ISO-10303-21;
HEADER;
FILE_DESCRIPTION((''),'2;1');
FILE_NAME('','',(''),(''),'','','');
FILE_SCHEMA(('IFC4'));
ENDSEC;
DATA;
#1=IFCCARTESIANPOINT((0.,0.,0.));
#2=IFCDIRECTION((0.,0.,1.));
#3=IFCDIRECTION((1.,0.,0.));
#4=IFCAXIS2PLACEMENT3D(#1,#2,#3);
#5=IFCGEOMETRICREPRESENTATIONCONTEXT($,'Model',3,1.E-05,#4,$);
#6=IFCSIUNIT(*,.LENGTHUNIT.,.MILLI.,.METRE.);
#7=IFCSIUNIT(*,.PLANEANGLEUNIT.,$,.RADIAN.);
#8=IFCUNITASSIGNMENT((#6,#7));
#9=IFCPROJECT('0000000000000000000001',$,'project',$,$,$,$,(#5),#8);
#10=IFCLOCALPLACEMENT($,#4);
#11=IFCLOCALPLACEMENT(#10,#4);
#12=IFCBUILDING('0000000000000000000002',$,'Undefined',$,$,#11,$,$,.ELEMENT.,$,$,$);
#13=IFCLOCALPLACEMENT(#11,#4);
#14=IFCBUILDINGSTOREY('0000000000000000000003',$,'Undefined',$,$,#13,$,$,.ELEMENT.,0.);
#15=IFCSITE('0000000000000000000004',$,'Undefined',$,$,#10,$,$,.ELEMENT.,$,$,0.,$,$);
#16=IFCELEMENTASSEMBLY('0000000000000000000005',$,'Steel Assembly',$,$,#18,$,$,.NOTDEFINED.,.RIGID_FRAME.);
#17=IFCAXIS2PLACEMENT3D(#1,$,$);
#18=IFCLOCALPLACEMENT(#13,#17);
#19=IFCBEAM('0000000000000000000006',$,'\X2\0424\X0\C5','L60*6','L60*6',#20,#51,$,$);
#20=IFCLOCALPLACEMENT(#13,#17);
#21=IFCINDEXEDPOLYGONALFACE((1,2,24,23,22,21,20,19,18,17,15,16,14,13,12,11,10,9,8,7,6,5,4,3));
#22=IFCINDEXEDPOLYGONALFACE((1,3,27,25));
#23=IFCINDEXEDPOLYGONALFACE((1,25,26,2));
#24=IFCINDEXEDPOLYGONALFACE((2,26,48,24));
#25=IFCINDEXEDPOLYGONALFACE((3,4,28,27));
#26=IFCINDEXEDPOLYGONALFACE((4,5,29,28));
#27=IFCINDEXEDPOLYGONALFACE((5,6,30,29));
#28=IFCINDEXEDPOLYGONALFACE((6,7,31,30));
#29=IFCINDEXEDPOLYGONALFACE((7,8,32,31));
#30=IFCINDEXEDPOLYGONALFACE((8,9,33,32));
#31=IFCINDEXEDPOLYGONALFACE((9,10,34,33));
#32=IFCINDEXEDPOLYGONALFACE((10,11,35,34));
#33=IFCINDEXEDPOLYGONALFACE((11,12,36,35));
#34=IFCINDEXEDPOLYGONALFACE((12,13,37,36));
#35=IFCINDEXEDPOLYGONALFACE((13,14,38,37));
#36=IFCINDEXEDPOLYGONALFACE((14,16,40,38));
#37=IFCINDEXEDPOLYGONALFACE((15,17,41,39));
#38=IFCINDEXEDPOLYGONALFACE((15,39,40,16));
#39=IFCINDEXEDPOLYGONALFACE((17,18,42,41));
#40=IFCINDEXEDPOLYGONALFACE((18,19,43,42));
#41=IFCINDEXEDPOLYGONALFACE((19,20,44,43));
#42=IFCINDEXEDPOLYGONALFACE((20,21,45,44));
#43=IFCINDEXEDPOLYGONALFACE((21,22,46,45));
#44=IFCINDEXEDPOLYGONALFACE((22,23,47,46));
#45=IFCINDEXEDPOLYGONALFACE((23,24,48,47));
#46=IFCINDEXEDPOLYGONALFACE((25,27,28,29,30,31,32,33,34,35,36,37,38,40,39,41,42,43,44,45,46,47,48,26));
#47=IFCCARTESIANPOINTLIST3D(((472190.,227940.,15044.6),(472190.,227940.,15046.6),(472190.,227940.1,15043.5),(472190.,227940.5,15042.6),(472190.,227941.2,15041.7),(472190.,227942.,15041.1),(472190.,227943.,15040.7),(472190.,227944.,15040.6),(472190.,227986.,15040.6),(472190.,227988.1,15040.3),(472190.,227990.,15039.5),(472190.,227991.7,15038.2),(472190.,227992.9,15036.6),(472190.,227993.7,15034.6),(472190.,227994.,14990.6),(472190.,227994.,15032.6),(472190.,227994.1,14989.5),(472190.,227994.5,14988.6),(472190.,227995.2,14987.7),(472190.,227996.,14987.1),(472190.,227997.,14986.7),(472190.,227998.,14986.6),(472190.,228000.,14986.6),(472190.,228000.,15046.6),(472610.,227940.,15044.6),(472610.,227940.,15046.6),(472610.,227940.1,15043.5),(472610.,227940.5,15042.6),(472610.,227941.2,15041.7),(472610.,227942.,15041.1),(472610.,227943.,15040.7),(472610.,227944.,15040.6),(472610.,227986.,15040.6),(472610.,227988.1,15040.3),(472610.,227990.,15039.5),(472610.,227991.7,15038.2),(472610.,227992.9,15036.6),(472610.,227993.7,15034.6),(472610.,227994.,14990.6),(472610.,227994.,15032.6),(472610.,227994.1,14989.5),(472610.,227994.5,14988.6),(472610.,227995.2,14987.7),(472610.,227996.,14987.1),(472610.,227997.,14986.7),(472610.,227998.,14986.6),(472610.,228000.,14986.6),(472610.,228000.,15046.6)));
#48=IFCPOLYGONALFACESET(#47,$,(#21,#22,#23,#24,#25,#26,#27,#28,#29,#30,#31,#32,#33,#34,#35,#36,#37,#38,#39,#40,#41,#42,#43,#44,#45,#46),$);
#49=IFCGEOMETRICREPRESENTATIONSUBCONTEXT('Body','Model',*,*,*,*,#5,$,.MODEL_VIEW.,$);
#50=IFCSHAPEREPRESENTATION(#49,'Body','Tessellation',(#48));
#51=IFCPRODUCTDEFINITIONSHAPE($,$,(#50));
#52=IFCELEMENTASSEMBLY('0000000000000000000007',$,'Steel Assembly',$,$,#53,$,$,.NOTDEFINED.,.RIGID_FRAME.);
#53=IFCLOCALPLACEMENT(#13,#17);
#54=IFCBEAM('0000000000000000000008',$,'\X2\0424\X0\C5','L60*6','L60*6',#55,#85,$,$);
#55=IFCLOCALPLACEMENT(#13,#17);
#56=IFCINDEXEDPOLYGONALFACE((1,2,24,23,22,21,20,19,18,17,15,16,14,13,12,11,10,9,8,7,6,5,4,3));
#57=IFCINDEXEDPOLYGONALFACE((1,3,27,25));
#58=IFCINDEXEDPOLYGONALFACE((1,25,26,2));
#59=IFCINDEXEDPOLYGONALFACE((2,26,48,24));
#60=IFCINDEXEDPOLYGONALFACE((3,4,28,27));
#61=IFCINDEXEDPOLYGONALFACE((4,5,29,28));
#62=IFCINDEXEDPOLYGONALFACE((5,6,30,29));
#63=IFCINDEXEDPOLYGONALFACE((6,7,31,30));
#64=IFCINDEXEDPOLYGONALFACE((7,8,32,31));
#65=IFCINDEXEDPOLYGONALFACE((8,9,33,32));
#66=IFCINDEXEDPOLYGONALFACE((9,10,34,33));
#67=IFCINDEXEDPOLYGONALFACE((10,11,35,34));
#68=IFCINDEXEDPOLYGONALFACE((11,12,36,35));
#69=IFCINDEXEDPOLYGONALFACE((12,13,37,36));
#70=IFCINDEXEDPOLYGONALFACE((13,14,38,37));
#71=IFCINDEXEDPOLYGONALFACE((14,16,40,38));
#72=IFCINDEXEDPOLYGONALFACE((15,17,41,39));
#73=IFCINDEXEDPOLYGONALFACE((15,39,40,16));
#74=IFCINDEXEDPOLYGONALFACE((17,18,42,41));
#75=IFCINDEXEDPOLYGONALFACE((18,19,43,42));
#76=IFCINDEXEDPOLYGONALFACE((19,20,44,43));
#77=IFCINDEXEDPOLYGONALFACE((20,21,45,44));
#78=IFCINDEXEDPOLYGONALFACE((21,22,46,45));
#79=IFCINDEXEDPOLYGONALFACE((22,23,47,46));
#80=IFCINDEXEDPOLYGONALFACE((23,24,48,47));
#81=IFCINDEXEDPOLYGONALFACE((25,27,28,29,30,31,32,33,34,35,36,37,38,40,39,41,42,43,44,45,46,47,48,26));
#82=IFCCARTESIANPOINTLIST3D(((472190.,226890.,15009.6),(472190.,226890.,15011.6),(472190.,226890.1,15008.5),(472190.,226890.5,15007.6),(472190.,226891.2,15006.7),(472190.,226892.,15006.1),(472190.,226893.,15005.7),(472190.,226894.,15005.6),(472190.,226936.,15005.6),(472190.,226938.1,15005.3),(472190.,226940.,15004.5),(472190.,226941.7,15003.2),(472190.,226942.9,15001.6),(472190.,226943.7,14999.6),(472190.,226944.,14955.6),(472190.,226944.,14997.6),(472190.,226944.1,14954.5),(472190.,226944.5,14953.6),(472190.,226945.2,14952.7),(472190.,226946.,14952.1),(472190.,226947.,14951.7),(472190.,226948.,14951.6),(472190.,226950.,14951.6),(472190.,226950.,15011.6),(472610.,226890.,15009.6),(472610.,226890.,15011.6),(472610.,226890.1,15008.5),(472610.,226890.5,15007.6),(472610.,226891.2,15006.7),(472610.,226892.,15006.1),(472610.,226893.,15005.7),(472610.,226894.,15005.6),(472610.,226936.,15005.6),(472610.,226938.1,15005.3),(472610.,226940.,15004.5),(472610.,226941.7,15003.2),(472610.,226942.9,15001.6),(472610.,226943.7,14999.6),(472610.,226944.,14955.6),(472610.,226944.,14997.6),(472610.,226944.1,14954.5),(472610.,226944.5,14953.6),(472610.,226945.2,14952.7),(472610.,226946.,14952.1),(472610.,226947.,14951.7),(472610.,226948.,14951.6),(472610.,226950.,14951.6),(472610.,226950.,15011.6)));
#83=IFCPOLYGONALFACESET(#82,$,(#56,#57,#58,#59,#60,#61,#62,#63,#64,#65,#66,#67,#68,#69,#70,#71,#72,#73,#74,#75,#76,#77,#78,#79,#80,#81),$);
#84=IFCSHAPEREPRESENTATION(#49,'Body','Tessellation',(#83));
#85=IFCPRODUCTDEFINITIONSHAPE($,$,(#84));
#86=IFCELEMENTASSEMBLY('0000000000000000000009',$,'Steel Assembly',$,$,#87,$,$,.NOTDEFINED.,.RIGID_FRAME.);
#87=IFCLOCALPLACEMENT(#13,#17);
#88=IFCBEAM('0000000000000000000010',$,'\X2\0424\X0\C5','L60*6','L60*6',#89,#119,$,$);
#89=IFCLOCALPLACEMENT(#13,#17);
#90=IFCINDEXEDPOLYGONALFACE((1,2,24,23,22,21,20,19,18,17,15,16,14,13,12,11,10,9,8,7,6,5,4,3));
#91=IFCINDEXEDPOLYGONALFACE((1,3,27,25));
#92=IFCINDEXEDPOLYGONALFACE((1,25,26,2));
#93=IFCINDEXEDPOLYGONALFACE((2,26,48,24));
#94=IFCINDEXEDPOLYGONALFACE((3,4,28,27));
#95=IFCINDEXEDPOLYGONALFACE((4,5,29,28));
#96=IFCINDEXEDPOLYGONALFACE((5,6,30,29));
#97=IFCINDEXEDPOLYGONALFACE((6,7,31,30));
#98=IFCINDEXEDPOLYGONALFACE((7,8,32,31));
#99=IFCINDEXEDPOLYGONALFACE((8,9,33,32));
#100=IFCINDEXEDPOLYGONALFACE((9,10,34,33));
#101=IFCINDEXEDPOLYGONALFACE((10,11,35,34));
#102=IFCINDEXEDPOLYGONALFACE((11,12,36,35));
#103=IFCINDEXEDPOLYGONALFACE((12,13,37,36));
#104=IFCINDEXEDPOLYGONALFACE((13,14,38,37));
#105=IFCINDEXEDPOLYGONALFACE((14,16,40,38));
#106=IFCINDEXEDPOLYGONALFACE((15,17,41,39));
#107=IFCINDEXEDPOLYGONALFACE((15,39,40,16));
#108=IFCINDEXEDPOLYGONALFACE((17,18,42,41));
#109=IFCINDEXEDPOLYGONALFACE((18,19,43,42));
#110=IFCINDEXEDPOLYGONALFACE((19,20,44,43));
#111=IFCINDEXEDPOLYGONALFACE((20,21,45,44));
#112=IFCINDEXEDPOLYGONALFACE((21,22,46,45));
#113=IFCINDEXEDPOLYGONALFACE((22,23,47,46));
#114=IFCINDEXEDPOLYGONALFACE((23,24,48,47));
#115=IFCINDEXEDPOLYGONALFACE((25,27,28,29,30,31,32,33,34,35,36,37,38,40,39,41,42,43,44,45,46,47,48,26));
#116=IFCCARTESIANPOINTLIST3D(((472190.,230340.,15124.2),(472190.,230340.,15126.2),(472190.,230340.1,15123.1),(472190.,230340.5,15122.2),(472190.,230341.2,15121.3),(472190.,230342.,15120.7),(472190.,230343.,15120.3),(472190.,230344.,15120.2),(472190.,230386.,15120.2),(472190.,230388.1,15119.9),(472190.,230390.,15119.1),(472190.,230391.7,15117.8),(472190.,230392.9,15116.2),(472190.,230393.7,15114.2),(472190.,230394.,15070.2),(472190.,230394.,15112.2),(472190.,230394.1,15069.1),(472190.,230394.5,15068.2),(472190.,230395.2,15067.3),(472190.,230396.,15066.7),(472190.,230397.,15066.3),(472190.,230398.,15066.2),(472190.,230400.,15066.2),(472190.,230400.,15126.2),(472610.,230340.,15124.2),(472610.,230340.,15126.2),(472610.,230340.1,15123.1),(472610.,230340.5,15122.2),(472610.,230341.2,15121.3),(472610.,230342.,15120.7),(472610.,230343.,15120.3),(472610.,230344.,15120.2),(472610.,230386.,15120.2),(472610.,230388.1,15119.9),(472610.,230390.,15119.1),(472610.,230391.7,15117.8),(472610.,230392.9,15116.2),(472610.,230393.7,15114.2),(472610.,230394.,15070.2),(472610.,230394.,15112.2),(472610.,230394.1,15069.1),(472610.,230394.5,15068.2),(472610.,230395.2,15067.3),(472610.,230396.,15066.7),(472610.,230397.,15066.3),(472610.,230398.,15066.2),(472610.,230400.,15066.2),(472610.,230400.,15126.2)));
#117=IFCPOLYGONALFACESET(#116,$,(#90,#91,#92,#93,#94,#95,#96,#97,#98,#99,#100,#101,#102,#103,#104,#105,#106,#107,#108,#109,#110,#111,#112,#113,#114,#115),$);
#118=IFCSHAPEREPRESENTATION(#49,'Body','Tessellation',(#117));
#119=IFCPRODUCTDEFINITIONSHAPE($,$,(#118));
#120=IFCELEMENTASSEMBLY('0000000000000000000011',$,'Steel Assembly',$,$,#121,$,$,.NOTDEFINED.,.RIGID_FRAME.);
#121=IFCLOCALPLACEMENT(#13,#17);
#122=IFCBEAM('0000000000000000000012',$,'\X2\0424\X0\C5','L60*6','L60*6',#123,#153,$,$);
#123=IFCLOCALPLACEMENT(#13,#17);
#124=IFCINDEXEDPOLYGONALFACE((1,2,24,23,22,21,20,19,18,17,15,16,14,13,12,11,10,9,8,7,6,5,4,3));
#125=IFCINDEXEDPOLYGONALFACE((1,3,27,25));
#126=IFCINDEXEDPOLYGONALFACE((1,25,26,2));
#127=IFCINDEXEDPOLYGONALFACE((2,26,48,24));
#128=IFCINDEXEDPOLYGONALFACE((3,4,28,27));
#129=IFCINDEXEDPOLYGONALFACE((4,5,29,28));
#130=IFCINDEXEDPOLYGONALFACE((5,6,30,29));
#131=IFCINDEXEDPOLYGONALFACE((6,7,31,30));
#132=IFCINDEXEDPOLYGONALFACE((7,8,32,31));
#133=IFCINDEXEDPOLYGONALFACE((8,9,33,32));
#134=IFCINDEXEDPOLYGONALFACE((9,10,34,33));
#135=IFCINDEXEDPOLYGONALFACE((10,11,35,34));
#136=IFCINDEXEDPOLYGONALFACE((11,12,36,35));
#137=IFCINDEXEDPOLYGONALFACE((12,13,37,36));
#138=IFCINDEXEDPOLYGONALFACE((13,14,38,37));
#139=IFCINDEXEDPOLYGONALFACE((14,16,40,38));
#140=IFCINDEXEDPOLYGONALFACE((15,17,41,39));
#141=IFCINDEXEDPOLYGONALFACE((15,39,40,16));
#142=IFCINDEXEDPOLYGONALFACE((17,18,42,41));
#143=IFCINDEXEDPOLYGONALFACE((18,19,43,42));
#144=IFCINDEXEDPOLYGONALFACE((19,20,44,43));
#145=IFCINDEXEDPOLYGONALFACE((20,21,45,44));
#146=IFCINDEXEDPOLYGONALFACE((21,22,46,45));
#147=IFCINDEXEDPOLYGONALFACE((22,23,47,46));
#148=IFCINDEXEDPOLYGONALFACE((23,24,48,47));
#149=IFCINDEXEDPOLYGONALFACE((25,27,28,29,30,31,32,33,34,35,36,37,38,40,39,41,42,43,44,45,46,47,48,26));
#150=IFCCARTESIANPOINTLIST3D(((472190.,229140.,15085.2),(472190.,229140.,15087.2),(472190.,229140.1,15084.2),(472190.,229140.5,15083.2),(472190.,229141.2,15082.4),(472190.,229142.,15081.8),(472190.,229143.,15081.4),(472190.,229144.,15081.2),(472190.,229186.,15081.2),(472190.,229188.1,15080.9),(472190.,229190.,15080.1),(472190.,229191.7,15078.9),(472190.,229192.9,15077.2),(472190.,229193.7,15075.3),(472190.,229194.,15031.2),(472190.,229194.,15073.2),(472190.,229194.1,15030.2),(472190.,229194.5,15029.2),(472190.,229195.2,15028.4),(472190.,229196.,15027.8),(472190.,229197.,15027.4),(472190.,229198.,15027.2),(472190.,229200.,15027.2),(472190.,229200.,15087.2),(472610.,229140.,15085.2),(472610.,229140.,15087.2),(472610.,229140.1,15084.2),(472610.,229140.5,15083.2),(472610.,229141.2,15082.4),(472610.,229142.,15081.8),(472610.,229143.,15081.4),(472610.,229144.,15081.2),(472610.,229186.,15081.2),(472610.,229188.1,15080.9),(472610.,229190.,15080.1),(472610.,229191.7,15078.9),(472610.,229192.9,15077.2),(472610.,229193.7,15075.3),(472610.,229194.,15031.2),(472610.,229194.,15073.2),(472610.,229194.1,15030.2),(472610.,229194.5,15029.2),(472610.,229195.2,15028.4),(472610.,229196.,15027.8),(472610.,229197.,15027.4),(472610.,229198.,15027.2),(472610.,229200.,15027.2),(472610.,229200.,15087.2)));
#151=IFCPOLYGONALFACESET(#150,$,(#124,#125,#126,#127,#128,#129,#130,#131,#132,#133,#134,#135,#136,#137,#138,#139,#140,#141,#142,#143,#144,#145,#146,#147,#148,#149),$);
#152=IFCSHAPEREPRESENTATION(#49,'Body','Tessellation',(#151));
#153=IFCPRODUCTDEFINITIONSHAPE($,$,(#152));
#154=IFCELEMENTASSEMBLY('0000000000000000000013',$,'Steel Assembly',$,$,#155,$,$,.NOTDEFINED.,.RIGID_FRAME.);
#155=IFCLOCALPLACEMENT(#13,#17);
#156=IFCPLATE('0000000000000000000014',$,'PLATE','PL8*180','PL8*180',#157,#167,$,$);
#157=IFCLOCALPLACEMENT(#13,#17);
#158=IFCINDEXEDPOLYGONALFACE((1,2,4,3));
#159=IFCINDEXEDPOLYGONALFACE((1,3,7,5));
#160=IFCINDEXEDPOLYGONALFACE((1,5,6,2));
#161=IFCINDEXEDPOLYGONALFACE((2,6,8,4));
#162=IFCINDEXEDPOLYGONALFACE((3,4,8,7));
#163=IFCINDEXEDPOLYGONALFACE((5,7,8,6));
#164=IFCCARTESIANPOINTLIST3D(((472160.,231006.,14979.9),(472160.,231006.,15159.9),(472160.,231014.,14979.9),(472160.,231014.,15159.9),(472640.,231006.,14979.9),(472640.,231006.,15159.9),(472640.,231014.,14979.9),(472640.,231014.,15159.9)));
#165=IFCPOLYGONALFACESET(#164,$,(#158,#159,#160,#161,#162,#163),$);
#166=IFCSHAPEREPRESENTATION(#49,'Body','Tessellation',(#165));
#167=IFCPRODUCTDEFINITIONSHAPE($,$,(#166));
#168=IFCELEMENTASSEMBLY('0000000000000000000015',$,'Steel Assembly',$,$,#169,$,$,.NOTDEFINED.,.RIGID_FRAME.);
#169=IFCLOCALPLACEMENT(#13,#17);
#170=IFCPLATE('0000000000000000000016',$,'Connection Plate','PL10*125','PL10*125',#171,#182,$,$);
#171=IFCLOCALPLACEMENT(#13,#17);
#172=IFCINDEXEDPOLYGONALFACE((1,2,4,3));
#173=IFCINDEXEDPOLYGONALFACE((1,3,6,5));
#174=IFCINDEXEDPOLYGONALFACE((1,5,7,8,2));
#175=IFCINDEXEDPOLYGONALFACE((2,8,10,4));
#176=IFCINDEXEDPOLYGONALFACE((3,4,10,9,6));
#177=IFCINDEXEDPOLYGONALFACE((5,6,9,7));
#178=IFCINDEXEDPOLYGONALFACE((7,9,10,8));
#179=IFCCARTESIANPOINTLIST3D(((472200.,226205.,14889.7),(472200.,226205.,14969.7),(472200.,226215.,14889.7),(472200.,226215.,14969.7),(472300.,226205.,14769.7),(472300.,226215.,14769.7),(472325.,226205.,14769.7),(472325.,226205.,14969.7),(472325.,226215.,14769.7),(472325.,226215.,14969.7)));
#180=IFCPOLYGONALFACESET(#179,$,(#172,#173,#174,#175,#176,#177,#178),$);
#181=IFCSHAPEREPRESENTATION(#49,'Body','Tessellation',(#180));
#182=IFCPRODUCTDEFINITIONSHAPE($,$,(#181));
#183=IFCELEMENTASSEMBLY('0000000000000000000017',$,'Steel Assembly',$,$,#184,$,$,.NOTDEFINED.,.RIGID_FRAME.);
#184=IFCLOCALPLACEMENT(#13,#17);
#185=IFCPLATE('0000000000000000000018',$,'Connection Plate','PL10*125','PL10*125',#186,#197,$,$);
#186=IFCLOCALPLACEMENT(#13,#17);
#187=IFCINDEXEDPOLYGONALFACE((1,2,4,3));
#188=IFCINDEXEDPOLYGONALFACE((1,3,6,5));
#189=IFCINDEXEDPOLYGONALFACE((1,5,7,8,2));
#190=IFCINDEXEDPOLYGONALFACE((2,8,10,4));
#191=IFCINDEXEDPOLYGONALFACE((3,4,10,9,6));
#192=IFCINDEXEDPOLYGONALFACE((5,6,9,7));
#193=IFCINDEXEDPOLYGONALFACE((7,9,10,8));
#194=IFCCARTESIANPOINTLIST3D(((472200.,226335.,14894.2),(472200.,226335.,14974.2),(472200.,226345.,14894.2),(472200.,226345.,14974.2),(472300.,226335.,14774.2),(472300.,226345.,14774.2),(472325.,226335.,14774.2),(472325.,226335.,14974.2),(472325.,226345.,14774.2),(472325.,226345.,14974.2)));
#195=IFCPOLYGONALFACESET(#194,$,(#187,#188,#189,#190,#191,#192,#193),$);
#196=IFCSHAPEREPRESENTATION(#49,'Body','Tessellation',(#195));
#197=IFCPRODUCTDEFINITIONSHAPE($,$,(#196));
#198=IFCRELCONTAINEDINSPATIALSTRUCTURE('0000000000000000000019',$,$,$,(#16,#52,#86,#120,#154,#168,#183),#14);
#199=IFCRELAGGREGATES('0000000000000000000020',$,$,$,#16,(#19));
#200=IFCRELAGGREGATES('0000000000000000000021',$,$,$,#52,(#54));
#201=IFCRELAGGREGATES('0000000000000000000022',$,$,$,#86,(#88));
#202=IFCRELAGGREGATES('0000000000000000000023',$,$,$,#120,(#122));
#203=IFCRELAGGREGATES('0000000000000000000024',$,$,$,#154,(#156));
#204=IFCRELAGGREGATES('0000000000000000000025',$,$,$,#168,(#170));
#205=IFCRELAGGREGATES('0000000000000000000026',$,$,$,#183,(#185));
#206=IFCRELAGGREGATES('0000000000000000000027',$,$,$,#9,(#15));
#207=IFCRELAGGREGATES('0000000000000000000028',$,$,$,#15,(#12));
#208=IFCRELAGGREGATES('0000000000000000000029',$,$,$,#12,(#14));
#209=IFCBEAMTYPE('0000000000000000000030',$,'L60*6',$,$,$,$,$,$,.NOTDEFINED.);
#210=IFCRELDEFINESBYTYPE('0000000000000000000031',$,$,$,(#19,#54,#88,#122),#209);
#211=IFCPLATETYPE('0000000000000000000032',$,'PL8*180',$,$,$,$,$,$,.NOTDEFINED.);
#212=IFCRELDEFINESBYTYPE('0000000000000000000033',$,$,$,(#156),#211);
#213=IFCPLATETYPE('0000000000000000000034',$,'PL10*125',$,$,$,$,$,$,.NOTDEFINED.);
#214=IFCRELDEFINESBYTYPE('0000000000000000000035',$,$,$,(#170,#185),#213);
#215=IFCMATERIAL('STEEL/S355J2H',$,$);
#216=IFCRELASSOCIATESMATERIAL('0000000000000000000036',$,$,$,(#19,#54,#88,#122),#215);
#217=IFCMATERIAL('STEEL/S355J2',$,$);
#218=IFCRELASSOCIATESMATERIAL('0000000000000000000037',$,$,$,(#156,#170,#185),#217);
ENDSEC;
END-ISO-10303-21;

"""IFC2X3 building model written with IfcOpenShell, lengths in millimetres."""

from ifc_helpers import new_model, si_unit, frame, origin_with_axes, origin_2d_with_axis, place, context, subcontext, project, spatial, polyline, l_section, outline, extrude, material, type_object, element, aggregate, save


model = new_model("IFC2X3")

# Units and contexts
model_context = context("Model", 3, precision=1e-05, world=origin_with_axes())
body_context = subcontext(model_context, "Body", "Model", "MODEL_VIEW")
ifc_project = project(units=[si_unit("LENGTHUNIT", "METRE", prefix="MILLI"), si_unit("PLANEANGLEUNIT", "RADIAN")], contexts=[model_context])

# Site, building, storey
site_placement = place(None, origin_with_axes())
site = spatial("IfcSite", under=ifc_project, at=site_placement, Name="Undefined", CompositionType="ELEMENT", RefElevation=0.0)
building_placement = place(site_placement, origin_with_axes())
building = spatial("IfcBuilding", under=site, at=building_placement, Name="Undefined", CompositionType="ELEMENT")
storey_placement = place(building_placement, origin_with_axes())
storey = spatial("IfcBuildingStorey", under=building, at=storey_placement, Name="Undefined", CompositionType="ELEMENT", Elevation=0.0)

# Element assemblies, beams
assembly_1_placement = place(storey_placement, origin_with_axes())
assembly_1 = element("IfcElementAssembly", 1, at=assembly_1_placement, inside=storey, Name="Steel Assembly", AssemblyPlace="NOTDEFINED", PredefinedType="RIGID_FRAME")
ifc_material_1 = material(Name="STEEL/S355J2H")
beam_type = type_object("IfcBeamType", Name="L60*6", PredefinedType="NOTDEFINED")
beam_1_placement = place(assembly_1_placement, frame((472190.0, 227970.0, 15016.6), z_axis=(0.0, -1.0, 0.0), x_axis=(1.0, 0.0, 0.0)))
beam_1 = element("IfcBeam", 2, at=beam_1_placement, type_object=beam_type, material=ifc_material_1, Name="ФC5", Description="L60*6", ObjectType="L60*6", context=body_context, shape_type="SweptSolid", body=[
    extrude(l_section(Depth=60.0, Width=60.0, Thickness=6.0, FilletRadius=8.0, EdgeRadius=4.0, at=origin_2d_with_axis()), frame((420.0, 0.0, 0.0), z_axis=(-1.0, 0.0, 0.0), x_axis=(0.0, -1.0, 0.0)), (0.0, 0.0, 1.0), 420.0),
])
aggregate(assembly_1, [beam_1])
assembly_2_placement = place(storey_placement, origin_with_axes())
assembly_2 = element("IfcElementAssembly", 3, at=assembly_2_placement, inside=storey, Name="Steel Assembly", AssemblyPlace="NOTDEFINED", PredefinedType="RIGID_FRAME")
beam_2_placement = place(assembly_2_placement, frame((472190.0, 226920.0, 14981.6), z_axis=(0.0, -1.0, 0.0), x_axis=(1.0, 0.0, 0.0)))
beam_2 = element("IfcBeam", 4, at=beam_2_placement, type_object=beam_type, material=ifc_material_1, Name="ФC5", Description="L60*6", ObjectType="L60*6", context=body_context, shape_type="SweptSolid", body=[
    extrude(l_section(Depth=60.0, Width=60.0, Thickness=6.0, FilletRadius=8.0, EdgeRadius=4.0, at=origin_2d_with_axis()), frame((420.0, 0.0, 0.0), z_axis=(-1.0, 0.0, 0.0), x_axis=(0.0, -1.0, 0.0)), (0.0, 0.0, 1.0), 420.0),
])
aggregate(assembly_2, [beam_2])
assembly_3_placement = place(storey_placement, origin_with_axes())
assembly_3 = element("IfcElementAssembly", 5, at=assembly_3_placement, inside=storey, Name="Steel Assembly", AssemblyPlace="NOTDEFINED", PredefinedType="RIGID_FRAME")
beam_3_placement = place(assembly_3_placement, frame((472190.0, 230370.0, 15096.2), z_axis=(0.0, -1.0, 0.0), x_axis=(1.0, 0.0, 0.0)))
beam_3 = element("IfcBeam", 6, at=beam_3_placement, type_object=beam_type, material=ifc_material_1, Name="ФC5", Description="L60*6", ObjectType="L60*6", context=body_context, shape_type="SweptSolid", body=[
    extrude(l_section(Depth=60.0, Width=60.0, Thickness=6.0, FilletRadius=8.0, EdgeRadius=4.0, at=origin_2d_with_axis()), frame((420.0, 0.0, 0.0), z_axis=(-1.0, 0.0, 0.0), x_axis=(0.0, -1.0, 0.0)), (0.0, 0.0, 1.0), 420.0),
])
aggregate(assembly_3, [beam_3])
assembly_4_placement = place(storey_placement, origin_with_axes())
assembly_4 = element("IfcElementAssembly", 7, at=assembly_4_placement, inside=storey, Name="Steel Assembly", AssemblyPlace="NOTDEFINED", PredefinedType="RIGID_FRAME")
beam_4_placement = place(assembly_4_placement, frame((472190.0, 229170.0, 15057.2), z_axis=(0.0, -1.0, 0.0), x_axis=(1.0, 0.0, 0.0)))
beam_4 = element("IfcBeam", 8, at=beam_4_placement, type_object=beam_type, material=ifc_material_1, Name="ФC5", Description="L60*6", ObjectType="L60*6", context=body_context, shape_type="SweptSolid", body=[
    extrude(l_section(Depth=60.0, Width=60.0, Thickness=6.0, FilletRadius=8.0, EdgeRadius=4.0, at=origin_2d_with_axis()), frame((420.0, 0.0, 0.0), z_axis=(-1.0, 0.0, 0.0), x_axis=(0.0, -1.0, 0.0)), (0.0, 0.0, 1.0), 420.0),
])
aggregate(assembly_4, [beam_4])

# Element assemblies, plates
assembly_5_placement = place(storey_placement, origin_with_axes())
assembly_5 = element("IfcElementAssembly", 9, at=assembly_5_placement, inside=storey, Name="Steel Assembly", AssemblyPlace="NOTDEFINED", PredefinedType="RIGID_FRAME")
ifc_material_2 = material(Name="STEEL/S355J2")
plate_type_1 = type_object("IfcPlateType", Name="PL8*180", PredefinedType="NOTDEFINED")
plate_1_placement = place(assembly_5_placement, frame((472160.0, 231010.0, 14979.9), z_axis=(0.0, 1.0, 0.0), x_axis=(0.0, 0.0, 1.0)))
plate_1 = element("IfcPlate", 10, at=plate_1_placement, type_object=plate_type_1, material=ifc_material_2, Name="PLATE", Description="PL8*180", ObjectType="PL8*180", context=body_context, shape_type="SweptSolid", body=[
    extrude(outline(polyline([(0.0, 0.0), (180.0, 0.0), (180.0, 480.0), (0.0, 480.0), (0.0, 0.0)])), frame((0.0, 0.0, -4.0), z_axis=(0.0, 0.0, 1.0), x_axis=(1.0, 0.0, 0.0)), (0.0, 0.0, 1.0), 8.0),
])
aggregate(assembly_5, [plate_1])
assembly_6_placement = place(storey_placement, origin_with_axes())
assembly_6 = element("IfcElementAssembly", 11, at=assembly_6_placement, inside=storey, Name="Steel Assembly", AssemblyPlace="NOTDEFINED", PredefinedType="RIGID_FRAME")
plate_type_2 = type_object("IfcPlateType", Name="PL10*125", PredefinedType="NOTDEFINED")
plate_2_placement = place(assembly_6_placement, frame((472200.0, 226210.0, 14969.7), z_axis=(0.0, 1.0, 0.0), x_axis=(1.0, 0.0, 0.0)))
plate_2 = element("IfcPlate", 12, at=plate_2_placement, type_object=plate_type_2, material=ifc_material_2, Name="Connection Plate", Description="PL10*125", ObjectType="PL10*125", context=body_context, shape_type="SweptSolid", body=[
    extrude(outline(polyline([(0.0, 0.0), (125.0, 0.0), (125.0, 200.0), (100.0, 200.0), (0.0, 80.0), (0.0, 0.0)])), frame((0.0, 0.0, -5.0), z_axis=(0.0, 0.0, 1.0), x_axis=(1.0, 0.0, 0.0)), (0.0, 0.0, 1.0), 10.0),
])
aggregate(assembly_6, [plate_2])
assembly_7_placement = place(storey_placement, origin_with_axes())
assembly_7 = element("IfcElementAssembly", 13, at=assembly_7_placement, inside=storey, Name="Steel Assembly", AssemblyPlace="NOTDEFINED", PredefinedType="RIGID_FRAME")
plate_3_placement = place(assembly_7_placement, frame((472200.0, 226340.0, 14974.2), z_axis=(0.0, 1.0, 0.0), x_axis=(1.0, 0.0, 0.0)))
plate_3 = element("IfcPlate", 14, at=plate_3_placement, type_object=plate_type_2, material=ifc_material_2, Name="Connection Plate", Description="PL10*125", ObjectType="PL10*125", context=body_context, shape_type="SweptSolid", body=[
    extrude(outline(polyline([(0.0, 0.0), (125.0, 0.0), (125.0, 200.0), (100.0, 200.0), (0.0, 80.0), (0.0, 0.0)])), frame((0.0, 0.0, -5.0), z_axis=(0.0, 0.0, 1.0), x_axis=(1.0, 0.0, 0.0)), (0.0, 0.0, 1.0), 10.0),
])
aggregate(assembly_7, [plate_3])

save(model, "model.ifc")
